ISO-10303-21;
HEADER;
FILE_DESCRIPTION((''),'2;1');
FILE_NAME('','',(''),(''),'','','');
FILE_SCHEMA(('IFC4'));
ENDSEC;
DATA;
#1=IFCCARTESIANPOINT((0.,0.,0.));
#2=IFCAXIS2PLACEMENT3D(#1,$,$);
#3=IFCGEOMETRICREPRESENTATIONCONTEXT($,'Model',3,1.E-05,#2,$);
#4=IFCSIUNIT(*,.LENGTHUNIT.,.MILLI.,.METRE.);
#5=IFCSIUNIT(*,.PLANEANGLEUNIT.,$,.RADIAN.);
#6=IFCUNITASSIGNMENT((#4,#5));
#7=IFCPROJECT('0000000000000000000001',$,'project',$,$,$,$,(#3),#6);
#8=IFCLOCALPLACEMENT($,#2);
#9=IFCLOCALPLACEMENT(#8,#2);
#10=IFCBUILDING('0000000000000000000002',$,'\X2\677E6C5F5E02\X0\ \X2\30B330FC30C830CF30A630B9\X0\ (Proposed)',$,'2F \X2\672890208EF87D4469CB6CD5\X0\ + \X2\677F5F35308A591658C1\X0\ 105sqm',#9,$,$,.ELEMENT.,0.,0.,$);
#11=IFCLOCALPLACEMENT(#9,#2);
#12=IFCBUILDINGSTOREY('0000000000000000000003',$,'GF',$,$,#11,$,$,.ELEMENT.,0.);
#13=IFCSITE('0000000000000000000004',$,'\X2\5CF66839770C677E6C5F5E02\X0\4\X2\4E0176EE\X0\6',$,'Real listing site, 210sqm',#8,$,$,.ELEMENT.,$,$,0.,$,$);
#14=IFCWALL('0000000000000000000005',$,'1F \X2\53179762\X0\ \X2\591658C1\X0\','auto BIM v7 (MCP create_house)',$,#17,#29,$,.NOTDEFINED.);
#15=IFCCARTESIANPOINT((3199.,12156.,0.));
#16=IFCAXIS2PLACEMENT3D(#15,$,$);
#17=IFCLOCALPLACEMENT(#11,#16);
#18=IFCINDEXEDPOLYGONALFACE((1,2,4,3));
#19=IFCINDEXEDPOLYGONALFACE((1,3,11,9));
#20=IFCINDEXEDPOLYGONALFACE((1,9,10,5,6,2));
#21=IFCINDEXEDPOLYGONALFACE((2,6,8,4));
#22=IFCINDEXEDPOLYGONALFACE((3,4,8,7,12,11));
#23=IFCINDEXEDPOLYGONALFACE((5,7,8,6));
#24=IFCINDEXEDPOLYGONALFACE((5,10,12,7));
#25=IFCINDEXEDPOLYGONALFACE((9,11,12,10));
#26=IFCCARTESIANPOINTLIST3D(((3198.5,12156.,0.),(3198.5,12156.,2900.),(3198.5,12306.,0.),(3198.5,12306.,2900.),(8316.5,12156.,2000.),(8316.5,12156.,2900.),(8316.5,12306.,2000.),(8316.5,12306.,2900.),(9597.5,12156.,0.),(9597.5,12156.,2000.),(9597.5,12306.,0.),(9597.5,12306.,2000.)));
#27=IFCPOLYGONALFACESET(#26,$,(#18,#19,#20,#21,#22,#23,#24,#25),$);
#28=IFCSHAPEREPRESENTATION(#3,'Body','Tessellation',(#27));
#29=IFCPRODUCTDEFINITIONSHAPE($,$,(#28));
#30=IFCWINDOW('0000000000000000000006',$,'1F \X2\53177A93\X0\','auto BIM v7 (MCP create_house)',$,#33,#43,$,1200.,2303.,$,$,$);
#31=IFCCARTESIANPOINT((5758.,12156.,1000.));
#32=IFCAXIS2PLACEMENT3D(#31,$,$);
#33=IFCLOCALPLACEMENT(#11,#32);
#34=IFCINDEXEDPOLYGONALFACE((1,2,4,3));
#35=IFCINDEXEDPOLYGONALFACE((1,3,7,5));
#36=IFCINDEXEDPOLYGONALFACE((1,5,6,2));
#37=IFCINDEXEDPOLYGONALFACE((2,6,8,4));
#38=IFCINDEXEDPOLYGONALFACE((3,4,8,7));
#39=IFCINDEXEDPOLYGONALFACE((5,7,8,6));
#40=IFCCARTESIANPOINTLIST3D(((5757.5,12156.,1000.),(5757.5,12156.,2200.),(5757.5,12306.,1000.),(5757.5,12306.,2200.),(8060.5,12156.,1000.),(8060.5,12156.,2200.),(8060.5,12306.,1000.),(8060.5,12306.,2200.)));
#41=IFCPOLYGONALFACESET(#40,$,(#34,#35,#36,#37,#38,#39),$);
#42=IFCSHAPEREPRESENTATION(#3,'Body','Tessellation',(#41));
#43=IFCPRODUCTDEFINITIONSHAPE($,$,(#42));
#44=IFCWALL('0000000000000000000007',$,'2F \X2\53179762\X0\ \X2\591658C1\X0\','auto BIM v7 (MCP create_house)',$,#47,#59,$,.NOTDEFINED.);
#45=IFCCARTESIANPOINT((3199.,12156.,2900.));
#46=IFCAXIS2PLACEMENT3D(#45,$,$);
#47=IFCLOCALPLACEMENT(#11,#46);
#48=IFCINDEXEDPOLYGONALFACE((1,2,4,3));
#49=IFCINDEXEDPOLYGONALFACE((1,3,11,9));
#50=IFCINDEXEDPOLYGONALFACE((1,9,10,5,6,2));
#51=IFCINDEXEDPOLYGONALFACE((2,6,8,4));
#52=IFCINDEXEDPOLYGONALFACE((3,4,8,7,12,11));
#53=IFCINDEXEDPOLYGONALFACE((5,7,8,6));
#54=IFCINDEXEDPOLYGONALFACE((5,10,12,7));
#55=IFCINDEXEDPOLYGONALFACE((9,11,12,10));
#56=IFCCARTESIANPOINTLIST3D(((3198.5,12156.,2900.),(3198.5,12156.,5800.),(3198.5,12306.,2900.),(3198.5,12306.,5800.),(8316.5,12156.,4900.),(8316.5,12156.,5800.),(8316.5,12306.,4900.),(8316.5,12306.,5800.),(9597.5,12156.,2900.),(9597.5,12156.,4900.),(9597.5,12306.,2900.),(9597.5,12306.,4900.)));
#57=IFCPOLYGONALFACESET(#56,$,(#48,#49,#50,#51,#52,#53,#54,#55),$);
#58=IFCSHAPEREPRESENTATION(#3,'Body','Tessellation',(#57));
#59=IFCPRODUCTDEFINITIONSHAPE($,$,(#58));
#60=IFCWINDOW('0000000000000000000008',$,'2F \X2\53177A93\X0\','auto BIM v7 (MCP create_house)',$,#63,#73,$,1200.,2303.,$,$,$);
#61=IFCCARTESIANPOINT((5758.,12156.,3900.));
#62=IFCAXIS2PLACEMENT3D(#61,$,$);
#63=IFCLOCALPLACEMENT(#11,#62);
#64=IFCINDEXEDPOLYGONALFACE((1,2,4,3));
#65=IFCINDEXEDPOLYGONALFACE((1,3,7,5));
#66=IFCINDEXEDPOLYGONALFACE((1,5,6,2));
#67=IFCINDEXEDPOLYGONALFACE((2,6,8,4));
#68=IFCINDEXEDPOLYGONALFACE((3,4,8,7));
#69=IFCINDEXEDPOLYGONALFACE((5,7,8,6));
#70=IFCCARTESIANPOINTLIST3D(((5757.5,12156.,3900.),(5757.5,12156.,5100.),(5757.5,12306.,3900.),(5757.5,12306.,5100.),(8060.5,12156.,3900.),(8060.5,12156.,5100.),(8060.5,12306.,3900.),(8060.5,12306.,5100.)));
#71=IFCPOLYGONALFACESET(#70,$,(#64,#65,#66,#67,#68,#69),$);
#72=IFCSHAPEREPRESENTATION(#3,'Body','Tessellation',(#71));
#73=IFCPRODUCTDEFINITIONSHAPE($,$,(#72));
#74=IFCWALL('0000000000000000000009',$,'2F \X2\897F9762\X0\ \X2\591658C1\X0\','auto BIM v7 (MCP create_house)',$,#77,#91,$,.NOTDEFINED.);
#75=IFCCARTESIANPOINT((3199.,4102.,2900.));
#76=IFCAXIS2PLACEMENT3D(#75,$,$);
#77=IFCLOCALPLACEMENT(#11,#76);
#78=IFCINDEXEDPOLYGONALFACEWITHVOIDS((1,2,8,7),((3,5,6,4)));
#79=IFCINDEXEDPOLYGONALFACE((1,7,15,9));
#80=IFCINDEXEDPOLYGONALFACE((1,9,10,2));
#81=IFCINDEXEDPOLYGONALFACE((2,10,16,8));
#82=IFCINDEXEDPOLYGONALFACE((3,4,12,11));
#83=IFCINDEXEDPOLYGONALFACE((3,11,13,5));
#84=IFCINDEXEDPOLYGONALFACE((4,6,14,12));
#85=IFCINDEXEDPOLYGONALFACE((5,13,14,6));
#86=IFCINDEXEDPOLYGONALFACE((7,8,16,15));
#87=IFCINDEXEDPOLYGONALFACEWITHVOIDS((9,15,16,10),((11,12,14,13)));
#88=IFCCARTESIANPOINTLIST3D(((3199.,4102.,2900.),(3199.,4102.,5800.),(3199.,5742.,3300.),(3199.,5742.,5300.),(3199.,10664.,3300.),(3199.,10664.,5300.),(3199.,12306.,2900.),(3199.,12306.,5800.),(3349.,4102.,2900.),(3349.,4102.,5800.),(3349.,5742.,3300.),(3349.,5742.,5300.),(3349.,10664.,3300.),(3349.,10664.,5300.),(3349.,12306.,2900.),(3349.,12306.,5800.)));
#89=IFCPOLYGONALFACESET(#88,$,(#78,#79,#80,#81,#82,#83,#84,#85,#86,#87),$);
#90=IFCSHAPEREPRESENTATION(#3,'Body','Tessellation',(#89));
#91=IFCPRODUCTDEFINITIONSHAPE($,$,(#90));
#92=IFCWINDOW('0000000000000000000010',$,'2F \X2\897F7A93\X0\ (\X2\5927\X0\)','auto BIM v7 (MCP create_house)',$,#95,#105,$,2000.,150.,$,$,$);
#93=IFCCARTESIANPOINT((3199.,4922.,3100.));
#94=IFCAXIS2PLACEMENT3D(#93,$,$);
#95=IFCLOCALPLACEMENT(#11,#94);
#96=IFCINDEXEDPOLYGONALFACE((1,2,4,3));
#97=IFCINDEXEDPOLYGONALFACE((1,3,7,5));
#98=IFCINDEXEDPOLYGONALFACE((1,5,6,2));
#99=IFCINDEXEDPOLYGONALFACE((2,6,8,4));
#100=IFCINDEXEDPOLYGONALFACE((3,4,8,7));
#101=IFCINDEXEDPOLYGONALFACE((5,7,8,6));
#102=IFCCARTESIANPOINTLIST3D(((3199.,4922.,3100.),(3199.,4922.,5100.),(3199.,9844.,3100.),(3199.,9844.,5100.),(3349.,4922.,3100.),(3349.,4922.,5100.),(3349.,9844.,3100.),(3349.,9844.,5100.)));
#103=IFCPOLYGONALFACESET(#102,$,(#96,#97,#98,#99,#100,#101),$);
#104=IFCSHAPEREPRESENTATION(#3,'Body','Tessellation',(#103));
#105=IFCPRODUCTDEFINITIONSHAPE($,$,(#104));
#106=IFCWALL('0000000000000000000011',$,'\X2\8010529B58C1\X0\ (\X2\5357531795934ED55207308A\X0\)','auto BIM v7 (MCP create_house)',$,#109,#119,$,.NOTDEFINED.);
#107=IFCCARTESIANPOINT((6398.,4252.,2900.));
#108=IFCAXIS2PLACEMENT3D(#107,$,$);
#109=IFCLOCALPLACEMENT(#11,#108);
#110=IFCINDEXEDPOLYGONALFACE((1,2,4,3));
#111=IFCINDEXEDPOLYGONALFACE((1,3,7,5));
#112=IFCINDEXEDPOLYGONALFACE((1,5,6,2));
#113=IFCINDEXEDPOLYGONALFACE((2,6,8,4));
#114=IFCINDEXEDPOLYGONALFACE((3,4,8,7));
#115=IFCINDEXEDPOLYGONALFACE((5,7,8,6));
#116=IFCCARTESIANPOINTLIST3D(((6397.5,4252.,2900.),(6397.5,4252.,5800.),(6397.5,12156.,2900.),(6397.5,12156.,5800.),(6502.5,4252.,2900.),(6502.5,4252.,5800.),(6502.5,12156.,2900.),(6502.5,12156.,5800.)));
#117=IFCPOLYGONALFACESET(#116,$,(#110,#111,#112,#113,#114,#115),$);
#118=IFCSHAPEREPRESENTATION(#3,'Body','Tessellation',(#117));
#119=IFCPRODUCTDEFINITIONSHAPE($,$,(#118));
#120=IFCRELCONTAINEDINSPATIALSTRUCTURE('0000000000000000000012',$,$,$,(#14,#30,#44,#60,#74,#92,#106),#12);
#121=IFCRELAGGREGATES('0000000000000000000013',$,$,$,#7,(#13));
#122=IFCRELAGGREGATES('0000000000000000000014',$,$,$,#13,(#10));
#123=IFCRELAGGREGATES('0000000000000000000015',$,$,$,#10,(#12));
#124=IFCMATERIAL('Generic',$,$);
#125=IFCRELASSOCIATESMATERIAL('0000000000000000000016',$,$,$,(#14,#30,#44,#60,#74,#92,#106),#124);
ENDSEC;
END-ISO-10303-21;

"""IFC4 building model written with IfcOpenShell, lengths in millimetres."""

from ifc_helpers import new_model, si_unit, frame, frame_2d, origin, place, context, project, spatial, rectangle, extrude, material, element, fill, save


model = new_model("IFC4")

# Units and contexts
model_context = context("Model", 3, precision=1e-05, world=origin())
ifc_project = project(units=[si_unit("LENGTHUNIT", "METRE", prefix="MILLI"), si_unit("PLANEANGLEUNIT", "RADIAN")], contexts=[model_context])

# Site, building, storey
site_placement = place(None, origin())
site = spatial("IfcSite", under=ifc_project, at=site_placement, Name="島根県松江市4丁目6", ObjectType="Real listing site, 210sqm", CompositionType="ELEMENT", RefElevation=0.0)
building_placement = place(site_placement, origin())
building = spatial("IfcBuilding", under=site, at=building_placement, Name="松江市 コートハウス (Proposed)", ObjectType="2F 木造軸組構法 + 板張り外壁 105sqm", CompositionType="ELEMENT", ElevationOfRefHeight=0.0, ElevationOfTerrain=0.0)
storey_placement = place(building_placement, origin())
storey = spatial("IfcBuildingStorey", under=building, at=storey_placement, Name="GF", CompositionType="ELEMENT", Elevation=0.0)

# Wall, opening, window
ifc_material = material(Name="Generic")
wall_1_placement = place(storey_placement, frame((3199.0, 12156.0, 0.0)))
wall_1 = element("IfcWall", 1, at=wall_1_placement, inside=storey, material=ifc_material, Name="1F 北面 外壁", Description="auto BIM v7 (MCP create_house)", PredefinedType="NOTDEFINED", context=model_context, shape_type="SweptSolid", body=[
    extrude(rectangle(XDim=6399.0, YDim=150.0, at=frame_2d((3199.0, 75.0))), frame((3199.0, 12156.0, 0.0)), (0.0, 0.0, 1.0), 2900.0),
])
opening_1_placement = place(storey_placement, frame((5758.0, 12156.0, 1000.0)))
opening_1 = element("IfcOpeningElement", 2, at=opening_1_placement, cuts=wall_1, PredefinedType="NOTDEFINED", context=model_context, shape_type="SweptSolid", body=[
    extrude(rectangle(XDim=2303.0, YDim=150.0, at=frame_2d((1151.0, 75.0))), frame((5758.0, 12156.0, 1000.0)), (0.0, 0.0, 1.0), 1200.0),
])
window_1_placement = place(storey_placement, frame((5758.0, 12156.0, 1000.0)))
window_1 = element("IfcWindow", 3, at=window_1_placement, inside=storey, material=ifc_material, Name="1F 北窓", Description="auto BIM v7 (MCP create_house)", OverallHeight=1200.0, OverallWidth=2303.0, context=model_context, shape_type="SweptSolid", body=[
    extrude(rectangle(XDim=2303.0, YDim=150.0, at=frame_2d((1151.0, 75.0))), frame((5758.0, 12156.0, 1000.0)), (0.0, 0.0, 1.0), 1200.0),
])
fill(opening_1, window_1)

# Walls, openings, windows
wall_2_placement = place(storey_placement, frame((3199.0, 12156.0, 2900.0)))
wall_2 = element("IfcWall", 4, at=wall_2_placement, inside=storey, material=ifc_material, Name="2F 北面 外壁", Description="auto BIM v7 (MCP create_house)", PredefinedType="NOTDEFINED", context=model_context, shape_type="SweptSolid", body=[
    extrude(rectangle(XDim=6399.0, YDim=150.0, at=frame_2d((3199.0, 75.0))), frame((3199.0, 12156.0, 2900.0)), (0.0, 0.0, 1.0), 2900.0),
])
opening_2_placement = place(storey_placement, frame((5758.0, 12156.0, 3900.0)))
opening_2 = element("IfcOpeningElement", 5, at=opening_2_placement, cuts=wall_2, PredefinedType="NOTDEFINED", context=model_context, shape_type="SweptSolid", body=[
    extrude(rectangle(XDim=2303.0, YDim=150.0, at=frame_2d((1151.0, 75.0))), frame((5758.0, 12156.0, 3900.0)), (0.0, 0.0, 1.0), 1200.0),
])
window_2_placement = place(storey_placement, frame((5758.0, 12156.0, 3900.0)))
window_2 = element("IfcWindow", 6, at=window_2_placement, inside=storey, material=ifc_material, Name="2F 北窓", Description="auto BIM v7 (MCP create_house)", OverallHeight=1200.0, OverallWidth=2303.0, context=model_context, shape_type="SweptSolid", body=[
    extrude(rectangle(XDim=2303.0, YDim=150.0, at=frame_2d((1151.0, 75.0))), frame((5758.0, 12156.0, 3900.0)), (0.0, 0.0, 1.0), 1200.0),
])
fill(opening_2, window_2)
wall_3_placement = place(storey_placement, frame((3199.0, 4102.0, 2900.0)))
wall_3 = element("IfcWall", 7, at=wall_3_placement, inside=storey, material=ifc_material, Name="2F 西面 外壁", Description="auto BIM v7 (MCP create_house)", PredefinedType="NOTDEFINED", context=model_context, shape_type="SweptSolid", body=[
    extrude(rectangle(XDim=150.0, YDim=8204.0, at=frame_2d((75.0, 4102.0))), frame((3199.0, 4102.0, 2900.0)), (0.0, 0.0, 1.0), 2900.0),
])
opening_3_placement = place(storey_placement, frame((3199.0, 4922.0, 3100.0)))
opening_3 = element("IfcOpeningElement", 8, at=opening_3_placement, cuts=wall_3, PredefinedType="NOTDEFINED", context=model_context, shape_type="SweptSolid", body=[
    extrude(rectangle(XDim=150.0, YDim=4922.0, at=frame_2d((75.0, 2461.0))), frame((3199.0, 4922.0, 3100.0)), (0.0, 0.0, 1.0), 2000.0),
])
window_3_placement = place(storey_placement, frame((3199.0, 4922.0, 3100.0)))
window_3 = element("IfcWindow", 9, at=window_3_placement, inside=storey, material=ifc_material, Name="2F 西窓 (大)", Description="auto BIM v7 (MCP create_house)", OverallHeight=2000.0, OverallWidth=150.0, context=model_context, shape_type="SweptSolid", body=[
    extrude(rectangle(XDim=150.0, YDim=4922.0, at=frame_2d((75.0, 2461.0))), frame((3199.0, 4922.0, 3100.0)), (0.0, 0.0, 1.0), 2000.0),
])
fill(opening_3, window_3)

# Wall
wall_4_placement = place(storey_placement, frame((6398.0, 4252.0, 2900.0)))
element("IfcWall", 10, at=wall_4_placement, inside=storey, material=ifc_material, Name="耐力壁 (南北間仕切り)", Description="auto BIM v7 (MCP create_house)", PredefinedType="NOTDEFINED", context=model_context, shape_type="SweptSolid", body=[
    extrude(rectangle(XDim=105.0, YDim=7904.0, at=frame_2d((52.0, 3952.0))), frame((6398.0, 4252.0, 2900.0)), (0.0, 0.0, 1.0), 2900.0),
])

save(model, "model.ifc")
